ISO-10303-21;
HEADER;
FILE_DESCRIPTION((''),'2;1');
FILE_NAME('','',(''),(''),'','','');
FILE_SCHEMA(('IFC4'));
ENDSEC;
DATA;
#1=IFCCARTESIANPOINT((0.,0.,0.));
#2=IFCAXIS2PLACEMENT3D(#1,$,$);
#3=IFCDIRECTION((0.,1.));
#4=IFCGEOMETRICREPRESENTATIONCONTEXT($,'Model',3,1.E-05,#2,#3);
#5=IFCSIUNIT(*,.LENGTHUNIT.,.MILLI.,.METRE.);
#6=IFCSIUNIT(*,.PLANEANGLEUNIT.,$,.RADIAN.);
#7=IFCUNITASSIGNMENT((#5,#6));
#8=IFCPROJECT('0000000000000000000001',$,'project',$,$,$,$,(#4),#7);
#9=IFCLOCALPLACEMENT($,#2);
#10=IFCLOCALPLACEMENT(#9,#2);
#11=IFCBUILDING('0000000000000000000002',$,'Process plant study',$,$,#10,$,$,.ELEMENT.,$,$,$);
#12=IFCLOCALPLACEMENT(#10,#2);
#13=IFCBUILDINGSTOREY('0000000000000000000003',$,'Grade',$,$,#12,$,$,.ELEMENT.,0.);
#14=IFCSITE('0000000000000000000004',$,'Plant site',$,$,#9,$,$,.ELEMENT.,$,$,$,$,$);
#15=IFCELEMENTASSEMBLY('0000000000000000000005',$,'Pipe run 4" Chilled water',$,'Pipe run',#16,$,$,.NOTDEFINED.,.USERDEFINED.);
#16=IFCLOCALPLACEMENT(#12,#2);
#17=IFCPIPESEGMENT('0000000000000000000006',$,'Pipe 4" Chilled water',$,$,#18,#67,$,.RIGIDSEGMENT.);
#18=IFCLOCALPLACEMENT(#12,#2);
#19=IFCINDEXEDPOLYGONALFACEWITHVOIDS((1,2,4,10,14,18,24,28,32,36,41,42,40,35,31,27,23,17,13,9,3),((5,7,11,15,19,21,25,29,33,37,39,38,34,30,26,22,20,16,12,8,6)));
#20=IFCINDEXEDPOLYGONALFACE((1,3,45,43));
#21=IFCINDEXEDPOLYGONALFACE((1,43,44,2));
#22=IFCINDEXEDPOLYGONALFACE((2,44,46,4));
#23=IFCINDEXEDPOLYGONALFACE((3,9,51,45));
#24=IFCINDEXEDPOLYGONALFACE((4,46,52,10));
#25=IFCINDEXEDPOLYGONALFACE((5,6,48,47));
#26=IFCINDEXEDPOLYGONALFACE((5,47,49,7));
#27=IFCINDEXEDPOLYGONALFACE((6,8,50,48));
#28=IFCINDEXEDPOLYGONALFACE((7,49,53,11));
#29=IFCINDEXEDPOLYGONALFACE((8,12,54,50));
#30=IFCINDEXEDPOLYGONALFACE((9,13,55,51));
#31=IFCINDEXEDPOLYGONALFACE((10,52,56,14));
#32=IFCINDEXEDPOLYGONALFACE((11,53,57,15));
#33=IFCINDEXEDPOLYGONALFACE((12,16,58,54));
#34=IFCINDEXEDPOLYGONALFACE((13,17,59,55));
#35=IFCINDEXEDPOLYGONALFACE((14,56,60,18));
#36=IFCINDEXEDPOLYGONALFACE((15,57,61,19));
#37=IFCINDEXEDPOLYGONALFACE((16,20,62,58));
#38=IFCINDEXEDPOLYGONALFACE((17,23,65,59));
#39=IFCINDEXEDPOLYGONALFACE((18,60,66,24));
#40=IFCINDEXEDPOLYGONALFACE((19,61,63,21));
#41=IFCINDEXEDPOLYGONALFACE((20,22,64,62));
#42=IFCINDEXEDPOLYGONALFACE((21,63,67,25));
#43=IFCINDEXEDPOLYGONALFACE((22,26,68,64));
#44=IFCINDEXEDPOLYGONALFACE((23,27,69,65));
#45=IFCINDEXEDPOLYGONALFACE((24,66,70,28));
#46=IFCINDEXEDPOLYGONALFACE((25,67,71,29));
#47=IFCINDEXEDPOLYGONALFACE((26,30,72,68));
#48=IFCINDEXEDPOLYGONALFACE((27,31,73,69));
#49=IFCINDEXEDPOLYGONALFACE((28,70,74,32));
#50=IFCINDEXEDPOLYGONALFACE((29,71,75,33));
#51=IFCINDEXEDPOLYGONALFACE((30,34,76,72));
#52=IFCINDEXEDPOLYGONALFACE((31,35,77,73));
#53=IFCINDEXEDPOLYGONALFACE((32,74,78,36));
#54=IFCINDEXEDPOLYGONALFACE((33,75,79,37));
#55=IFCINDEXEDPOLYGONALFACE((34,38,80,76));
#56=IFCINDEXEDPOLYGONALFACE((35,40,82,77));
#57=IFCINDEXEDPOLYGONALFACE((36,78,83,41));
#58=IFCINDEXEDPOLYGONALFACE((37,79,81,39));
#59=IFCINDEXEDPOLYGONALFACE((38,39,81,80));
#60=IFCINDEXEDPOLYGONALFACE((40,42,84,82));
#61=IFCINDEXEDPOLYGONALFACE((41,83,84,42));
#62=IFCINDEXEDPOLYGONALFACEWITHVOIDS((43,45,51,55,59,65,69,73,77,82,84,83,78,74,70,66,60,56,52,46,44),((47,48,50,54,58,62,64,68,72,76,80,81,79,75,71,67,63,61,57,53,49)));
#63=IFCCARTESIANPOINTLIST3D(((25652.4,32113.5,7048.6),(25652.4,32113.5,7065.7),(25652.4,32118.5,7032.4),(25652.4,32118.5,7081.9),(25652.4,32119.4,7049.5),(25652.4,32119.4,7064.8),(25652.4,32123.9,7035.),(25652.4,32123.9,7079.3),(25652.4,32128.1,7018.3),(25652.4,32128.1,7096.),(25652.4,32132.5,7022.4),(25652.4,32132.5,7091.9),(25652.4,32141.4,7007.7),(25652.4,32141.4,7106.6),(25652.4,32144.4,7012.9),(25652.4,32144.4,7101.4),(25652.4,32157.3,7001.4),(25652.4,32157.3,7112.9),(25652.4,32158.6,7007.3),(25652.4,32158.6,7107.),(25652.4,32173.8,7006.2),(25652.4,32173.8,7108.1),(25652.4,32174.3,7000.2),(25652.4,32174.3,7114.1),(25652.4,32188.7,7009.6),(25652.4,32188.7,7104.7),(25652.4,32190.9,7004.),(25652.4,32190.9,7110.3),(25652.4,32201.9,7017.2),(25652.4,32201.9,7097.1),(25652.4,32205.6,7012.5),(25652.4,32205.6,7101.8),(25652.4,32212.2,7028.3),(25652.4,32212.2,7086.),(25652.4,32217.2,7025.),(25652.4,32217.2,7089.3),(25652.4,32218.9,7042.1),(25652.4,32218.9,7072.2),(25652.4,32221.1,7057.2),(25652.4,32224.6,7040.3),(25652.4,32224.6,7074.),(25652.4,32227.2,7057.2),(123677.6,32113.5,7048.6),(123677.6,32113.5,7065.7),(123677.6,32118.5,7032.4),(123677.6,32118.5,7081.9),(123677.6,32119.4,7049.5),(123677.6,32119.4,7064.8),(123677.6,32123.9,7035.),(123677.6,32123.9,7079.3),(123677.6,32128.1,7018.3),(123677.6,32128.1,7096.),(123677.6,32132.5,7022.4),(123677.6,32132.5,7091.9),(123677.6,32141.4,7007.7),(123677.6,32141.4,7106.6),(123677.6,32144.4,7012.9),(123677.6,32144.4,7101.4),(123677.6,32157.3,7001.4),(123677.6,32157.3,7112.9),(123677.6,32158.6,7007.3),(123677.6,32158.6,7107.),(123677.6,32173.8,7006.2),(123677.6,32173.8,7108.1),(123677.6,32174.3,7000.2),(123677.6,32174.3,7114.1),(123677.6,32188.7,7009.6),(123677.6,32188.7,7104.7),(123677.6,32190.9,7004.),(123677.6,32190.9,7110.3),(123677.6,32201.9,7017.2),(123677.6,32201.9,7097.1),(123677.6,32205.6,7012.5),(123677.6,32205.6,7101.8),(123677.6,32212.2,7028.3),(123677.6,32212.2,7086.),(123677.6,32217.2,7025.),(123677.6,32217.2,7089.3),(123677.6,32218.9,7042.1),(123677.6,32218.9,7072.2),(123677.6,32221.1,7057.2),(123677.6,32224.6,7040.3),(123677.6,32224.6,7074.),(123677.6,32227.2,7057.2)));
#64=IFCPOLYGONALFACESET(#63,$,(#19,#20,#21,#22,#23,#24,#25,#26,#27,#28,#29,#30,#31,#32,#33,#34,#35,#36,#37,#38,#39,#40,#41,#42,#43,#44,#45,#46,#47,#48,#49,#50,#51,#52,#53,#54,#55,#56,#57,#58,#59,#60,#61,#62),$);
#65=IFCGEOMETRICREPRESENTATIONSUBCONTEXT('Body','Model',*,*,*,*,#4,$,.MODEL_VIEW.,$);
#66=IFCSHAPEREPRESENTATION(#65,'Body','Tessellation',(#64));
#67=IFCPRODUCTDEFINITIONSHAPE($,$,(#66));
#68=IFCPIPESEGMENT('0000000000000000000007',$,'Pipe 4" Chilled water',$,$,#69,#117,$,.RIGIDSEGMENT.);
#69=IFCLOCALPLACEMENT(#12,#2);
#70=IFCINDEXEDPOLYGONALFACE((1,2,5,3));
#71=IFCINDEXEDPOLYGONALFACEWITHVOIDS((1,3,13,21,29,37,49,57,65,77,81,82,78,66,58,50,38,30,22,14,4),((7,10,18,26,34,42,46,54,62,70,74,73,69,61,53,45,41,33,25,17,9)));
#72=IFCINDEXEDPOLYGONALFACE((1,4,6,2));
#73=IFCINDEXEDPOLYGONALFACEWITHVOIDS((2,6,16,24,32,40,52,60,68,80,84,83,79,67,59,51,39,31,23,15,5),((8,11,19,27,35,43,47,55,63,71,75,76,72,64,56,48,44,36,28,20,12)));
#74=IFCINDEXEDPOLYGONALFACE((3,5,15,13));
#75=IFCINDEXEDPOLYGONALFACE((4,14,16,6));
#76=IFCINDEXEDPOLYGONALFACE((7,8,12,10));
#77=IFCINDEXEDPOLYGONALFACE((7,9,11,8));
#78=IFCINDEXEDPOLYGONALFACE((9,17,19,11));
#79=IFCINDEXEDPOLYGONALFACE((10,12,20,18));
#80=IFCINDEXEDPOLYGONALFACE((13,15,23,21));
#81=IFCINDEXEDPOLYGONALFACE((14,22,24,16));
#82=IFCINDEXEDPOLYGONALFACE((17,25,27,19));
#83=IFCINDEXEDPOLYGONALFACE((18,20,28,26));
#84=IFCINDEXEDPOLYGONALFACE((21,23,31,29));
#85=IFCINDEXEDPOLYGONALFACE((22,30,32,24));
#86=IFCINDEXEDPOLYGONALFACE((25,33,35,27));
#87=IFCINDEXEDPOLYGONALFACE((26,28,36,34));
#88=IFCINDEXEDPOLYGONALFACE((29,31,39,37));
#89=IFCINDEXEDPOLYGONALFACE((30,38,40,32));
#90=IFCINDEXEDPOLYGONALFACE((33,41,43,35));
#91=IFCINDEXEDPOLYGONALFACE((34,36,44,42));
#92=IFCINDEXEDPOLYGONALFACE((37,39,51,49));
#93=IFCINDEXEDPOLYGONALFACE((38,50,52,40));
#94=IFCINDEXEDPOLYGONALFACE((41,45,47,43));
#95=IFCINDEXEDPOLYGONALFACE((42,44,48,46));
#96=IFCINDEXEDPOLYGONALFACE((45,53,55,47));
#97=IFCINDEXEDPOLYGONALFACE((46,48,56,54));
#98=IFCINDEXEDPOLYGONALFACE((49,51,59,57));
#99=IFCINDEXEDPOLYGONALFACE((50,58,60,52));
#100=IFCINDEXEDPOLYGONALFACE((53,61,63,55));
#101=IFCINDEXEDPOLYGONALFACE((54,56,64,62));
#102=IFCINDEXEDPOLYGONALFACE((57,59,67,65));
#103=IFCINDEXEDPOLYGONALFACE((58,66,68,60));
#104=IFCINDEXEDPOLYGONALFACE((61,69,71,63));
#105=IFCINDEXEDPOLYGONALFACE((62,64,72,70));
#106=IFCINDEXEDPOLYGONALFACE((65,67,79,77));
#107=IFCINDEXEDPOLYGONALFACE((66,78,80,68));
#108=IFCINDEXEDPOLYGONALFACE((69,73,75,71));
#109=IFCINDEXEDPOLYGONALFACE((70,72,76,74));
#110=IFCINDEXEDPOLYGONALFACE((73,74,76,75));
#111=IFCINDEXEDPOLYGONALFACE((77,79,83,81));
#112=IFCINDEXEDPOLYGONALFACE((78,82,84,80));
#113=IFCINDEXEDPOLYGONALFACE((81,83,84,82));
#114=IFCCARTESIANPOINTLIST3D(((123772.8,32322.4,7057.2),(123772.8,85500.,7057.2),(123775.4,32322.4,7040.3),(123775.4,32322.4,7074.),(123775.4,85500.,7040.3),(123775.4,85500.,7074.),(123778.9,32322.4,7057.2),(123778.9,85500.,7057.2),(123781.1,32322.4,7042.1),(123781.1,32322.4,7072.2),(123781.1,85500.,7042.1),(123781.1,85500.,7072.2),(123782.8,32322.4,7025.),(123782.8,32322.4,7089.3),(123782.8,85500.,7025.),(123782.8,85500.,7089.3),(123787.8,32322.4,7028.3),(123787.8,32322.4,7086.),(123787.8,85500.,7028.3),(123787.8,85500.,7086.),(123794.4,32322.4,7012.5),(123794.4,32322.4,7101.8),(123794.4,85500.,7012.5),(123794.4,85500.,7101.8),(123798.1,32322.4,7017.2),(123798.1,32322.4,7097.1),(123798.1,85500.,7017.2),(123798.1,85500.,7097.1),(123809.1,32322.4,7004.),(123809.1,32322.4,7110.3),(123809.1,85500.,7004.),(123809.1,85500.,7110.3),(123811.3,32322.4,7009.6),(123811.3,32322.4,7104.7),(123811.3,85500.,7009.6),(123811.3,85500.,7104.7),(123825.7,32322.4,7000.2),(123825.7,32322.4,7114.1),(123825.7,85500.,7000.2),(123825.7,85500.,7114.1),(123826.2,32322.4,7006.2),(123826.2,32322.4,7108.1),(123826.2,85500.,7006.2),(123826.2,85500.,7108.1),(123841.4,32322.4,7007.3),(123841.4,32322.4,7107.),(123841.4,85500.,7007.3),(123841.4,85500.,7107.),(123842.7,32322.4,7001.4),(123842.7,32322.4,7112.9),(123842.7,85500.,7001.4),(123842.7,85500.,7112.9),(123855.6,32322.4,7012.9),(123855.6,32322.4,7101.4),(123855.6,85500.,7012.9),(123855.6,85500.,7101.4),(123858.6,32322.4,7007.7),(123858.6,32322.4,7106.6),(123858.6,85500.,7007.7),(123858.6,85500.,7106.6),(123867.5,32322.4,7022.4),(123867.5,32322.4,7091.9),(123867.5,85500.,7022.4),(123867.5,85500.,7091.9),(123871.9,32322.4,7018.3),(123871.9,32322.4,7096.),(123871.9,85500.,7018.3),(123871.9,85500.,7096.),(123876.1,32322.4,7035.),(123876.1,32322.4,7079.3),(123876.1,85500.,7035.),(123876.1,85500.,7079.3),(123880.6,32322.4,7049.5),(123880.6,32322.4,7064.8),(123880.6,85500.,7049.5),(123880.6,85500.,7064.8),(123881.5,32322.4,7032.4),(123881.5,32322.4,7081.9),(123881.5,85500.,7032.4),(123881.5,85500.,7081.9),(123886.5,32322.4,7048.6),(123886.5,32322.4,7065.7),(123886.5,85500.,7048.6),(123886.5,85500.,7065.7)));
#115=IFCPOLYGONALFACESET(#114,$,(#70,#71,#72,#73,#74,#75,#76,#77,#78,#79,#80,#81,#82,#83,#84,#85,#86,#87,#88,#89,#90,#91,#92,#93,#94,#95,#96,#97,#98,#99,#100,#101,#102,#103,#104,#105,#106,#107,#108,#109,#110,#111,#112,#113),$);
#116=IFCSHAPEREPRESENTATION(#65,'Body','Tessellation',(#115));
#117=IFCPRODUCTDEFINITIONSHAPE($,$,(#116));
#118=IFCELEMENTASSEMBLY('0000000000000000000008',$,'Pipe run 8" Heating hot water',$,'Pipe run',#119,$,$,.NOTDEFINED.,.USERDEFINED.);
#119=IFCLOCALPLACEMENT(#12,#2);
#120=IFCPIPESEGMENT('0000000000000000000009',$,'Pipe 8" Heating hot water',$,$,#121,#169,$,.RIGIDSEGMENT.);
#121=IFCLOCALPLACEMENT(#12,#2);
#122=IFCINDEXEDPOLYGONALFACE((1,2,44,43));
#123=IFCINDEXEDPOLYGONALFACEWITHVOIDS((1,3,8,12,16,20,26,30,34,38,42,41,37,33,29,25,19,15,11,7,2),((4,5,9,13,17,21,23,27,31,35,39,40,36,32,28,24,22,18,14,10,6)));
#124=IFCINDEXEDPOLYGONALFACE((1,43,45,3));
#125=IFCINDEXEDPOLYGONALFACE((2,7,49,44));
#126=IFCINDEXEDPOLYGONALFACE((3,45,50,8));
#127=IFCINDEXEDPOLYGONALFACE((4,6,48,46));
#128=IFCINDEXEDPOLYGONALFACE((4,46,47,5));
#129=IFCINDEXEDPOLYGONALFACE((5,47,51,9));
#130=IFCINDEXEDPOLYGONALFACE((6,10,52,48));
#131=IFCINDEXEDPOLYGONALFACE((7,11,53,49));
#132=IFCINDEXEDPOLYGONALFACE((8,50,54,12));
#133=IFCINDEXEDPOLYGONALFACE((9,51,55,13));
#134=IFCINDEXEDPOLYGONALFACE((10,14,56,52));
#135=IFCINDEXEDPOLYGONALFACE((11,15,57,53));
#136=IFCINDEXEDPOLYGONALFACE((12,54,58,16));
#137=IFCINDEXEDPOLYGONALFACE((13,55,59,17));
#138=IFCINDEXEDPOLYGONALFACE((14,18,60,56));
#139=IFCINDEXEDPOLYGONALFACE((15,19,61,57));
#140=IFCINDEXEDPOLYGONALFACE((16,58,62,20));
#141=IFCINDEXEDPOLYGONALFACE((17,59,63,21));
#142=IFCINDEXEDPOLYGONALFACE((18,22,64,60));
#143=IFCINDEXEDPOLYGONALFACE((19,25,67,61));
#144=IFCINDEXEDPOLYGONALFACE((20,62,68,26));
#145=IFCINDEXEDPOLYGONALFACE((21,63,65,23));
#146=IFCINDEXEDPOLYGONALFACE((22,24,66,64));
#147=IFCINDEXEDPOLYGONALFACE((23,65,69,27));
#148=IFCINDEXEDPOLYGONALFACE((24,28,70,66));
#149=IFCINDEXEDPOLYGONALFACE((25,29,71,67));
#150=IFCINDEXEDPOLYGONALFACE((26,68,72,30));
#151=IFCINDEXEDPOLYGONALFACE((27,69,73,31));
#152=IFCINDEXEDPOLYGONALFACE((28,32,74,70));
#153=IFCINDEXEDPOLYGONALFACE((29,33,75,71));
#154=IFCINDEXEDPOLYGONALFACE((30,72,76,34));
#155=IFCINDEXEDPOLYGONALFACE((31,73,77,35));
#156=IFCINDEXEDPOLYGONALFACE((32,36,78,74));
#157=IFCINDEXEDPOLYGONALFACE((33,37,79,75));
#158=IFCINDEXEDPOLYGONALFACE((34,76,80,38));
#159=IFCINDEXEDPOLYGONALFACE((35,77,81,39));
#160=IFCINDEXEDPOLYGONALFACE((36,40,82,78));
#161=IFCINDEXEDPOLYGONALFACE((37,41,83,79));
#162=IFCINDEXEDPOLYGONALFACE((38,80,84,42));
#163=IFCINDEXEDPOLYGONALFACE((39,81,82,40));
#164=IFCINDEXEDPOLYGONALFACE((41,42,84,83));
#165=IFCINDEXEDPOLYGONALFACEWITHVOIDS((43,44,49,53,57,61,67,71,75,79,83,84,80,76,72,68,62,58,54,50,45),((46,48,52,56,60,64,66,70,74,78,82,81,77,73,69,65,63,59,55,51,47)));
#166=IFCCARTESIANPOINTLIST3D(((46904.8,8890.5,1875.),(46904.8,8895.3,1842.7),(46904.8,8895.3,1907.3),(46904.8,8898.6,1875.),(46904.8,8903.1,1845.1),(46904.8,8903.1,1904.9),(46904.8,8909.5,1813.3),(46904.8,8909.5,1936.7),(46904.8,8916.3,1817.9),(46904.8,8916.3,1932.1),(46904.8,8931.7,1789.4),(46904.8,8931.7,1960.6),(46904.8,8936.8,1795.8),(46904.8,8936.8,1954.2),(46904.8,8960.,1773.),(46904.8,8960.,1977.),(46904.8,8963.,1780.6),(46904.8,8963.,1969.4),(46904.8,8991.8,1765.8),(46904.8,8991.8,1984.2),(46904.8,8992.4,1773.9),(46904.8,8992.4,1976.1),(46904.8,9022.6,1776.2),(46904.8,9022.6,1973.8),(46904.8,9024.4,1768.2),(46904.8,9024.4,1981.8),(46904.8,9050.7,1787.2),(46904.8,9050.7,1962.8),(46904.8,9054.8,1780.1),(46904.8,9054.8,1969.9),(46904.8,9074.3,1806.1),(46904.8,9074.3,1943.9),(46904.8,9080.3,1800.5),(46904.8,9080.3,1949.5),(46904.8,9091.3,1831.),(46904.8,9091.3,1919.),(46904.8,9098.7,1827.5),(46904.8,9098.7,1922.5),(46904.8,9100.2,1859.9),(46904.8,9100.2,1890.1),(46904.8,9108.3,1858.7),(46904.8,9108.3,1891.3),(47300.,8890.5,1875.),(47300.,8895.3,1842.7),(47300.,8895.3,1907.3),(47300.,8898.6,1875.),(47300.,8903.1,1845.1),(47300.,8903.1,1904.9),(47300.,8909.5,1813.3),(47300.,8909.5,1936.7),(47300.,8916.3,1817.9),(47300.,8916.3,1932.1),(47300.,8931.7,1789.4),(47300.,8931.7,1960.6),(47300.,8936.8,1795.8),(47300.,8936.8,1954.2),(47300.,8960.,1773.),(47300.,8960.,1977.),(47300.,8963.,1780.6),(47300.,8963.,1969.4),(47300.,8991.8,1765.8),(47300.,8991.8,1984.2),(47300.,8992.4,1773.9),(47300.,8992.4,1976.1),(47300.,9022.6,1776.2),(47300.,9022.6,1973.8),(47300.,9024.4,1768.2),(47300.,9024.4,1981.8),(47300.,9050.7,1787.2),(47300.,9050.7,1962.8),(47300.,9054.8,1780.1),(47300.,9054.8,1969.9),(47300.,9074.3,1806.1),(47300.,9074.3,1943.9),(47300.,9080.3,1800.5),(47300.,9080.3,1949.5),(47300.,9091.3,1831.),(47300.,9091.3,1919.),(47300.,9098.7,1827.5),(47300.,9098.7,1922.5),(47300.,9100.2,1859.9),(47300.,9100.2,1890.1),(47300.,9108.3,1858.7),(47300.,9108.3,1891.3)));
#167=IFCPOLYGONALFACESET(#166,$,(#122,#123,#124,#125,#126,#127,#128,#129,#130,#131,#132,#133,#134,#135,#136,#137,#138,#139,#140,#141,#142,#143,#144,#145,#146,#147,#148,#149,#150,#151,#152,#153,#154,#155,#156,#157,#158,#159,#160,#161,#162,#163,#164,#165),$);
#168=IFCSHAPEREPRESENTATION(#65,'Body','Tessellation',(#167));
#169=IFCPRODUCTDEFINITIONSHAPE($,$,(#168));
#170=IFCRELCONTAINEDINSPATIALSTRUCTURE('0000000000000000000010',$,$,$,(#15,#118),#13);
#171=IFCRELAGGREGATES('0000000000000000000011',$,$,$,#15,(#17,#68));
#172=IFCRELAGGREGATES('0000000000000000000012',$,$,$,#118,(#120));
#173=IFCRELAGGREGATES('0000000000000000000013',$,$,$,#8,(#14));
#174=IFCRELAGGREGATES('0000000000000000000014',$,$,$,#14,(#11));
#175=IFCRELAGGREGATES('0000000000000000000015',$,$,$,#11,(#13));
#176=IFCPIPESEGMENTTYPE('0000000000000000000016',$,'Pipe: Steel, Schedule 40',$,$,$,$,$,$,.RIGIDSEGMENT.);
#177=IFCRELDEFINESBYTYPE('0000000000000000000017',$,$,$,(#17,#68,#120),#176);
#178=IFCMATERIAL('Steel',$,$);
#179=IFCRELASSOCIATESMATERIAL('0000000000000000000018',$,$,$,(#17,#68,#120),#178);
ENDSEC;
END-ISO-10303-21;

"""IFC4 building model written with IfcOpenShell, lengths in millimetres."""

from ifc_helpers import new_model, si_unit, direction, frame, origin, origin_with_axes, origin_2d, place, context, subcontext, project, spatial, hollow_circle, extrude, material, type_object, element, aggregate, save


model = new_model("IFC4")

# Units and contexts
model_context = context("Model", 3, precision=1e-05, world=origin(), true_north=direction((0.0, 1.0)))
body_context = subcontext(model_context, "Body", "Model", "MODEL_VIEW")
ifc_project = project(units=[si_unit("LENGTHUNIT", "METRE", prefix="MILLI"), si_unit("PLANEANGLEUNIT", "RADIAN")], contexts=[model_context])

# Site, building, storey
site_placement = place(None, origin())
site = spatial("IfcSite", under=ifc_project, at=site_placement, Name="Plant site", CompositionType="ELEMENT")
building_placement = place(site_placement, origin())
building = spatial("IfcBuilding", under=site, at=building_placement, Name="Process plant study", CompositionType="ELEMENT")
storey_placement = place(building_placement, origin())
storey = spatial("IfcBuildingStorey", under=building, at=storey_placement, Name="Grade", CompositionType="ELEMENT", Elevation=0.0)

# Element assemblies, pipe segments
assembly_1_placement = place(storey_placement, origin_with_axes())
assembly_1 = element("IfcElementAssembly", 1, at=assembly_1_placement, inside=storey, Name="Pipe run 4\" Chilled water", ObjectType="Pipe run", AssemblyPlace="NOTDEFINED", PredefinedType="USERDEFINED")
ifc_material = material(Name="Steel")
pipe_segment_type = type_object("IfcPipeSegmentType", Name="Pipe: Steel, Schedule 40", PredefinedType="RIGIDSEGMENT")
pipe_segment_1_placement = place(storey_placement, origin_with_axes())
pipe_segment_1 = element("IfcPipeSegment", 2, at=pipe_segment_1_placement, type_object=pipe_segment_type, material=ifc_material, Name="Pipe 4\" Chilled water", PredefinedType="RIGIDSEGMENT", context=body_context, shape_type="SweptSolid", body=[
    extrude(hollow_circle(Radius=57.1, WallThickness=6.0, at=origin_2d()), frame((25652.4, 32170.0, 7057.1), z_axis=(1.0, 0.0, 0.0), x_axis=(0.0, 1.0, 0.0)), (0.0, 0.0, 1.0), 98025.2),
])
pipe_segment_2_placement = place(storey_placement, origin_with_axes())
pipe_segment_2 = element("IfcPipeSegment", 3, at=pipe_segment_2_placement, type_object=pipe_segment_type, material=ifc_material, Name="Pipe 4\" Chilled water", PredefinedType="RIGIDSEGMENT", context=body_context, shape_type="SweptSolid", body=[
    extrude(hollow_circle(Radius=57.1, WallThickness=6.0, at=origin_2d()), frame((123830.0, 32322.4, 7057.1), z_axis=(0.0, 1.0, 0.0), x_axis=(-1.0, 0.0, 0.0)), (0.0, 0.0, 1.0), 53177.6),
])
assembly_2_placement = place(storey_placement, origin_with_axes())
assembly_2 = element("IfcElementAssembly", 4, at=assembly_2_placement, inside=storey, Name="Pipe run 8\" Heating hot water", ObjectType="Pipe run", AssemblyPlace="NOTDEFINED", PredefinedType="USERDEFINED")
pipe_segment_3_placement = place(storey_placement, origin_with_axes())
pipe_segment_3 = element("IfcPipeSegment", 5, at=pipe_segment_3_placement, type_object=pipe_segment_type, material=ifc_material, Name="Pipe 8\" Heating hot water", PredefinedType="RIGIDSEGMENT", context=body_context, shape_type="SweptSolid", body=[
    extrude(hollow_circle(Radius=109.5, WallThickness=8.2, at=origin_2d()), frame((47300.0, 9000.0, 1875.0), z_axis=(-1.0, 0.0, 0.0), x_axis=(0.0, -1.0, 0.0)), (0.0, 0.0, 1.0), 395.2),
])

aggregate(assembly_1, [pipe_segment_1, pipe_segment_2])
aggregate(assembly_2, [pipe_segment_3])

save(model, "model.ifc")
